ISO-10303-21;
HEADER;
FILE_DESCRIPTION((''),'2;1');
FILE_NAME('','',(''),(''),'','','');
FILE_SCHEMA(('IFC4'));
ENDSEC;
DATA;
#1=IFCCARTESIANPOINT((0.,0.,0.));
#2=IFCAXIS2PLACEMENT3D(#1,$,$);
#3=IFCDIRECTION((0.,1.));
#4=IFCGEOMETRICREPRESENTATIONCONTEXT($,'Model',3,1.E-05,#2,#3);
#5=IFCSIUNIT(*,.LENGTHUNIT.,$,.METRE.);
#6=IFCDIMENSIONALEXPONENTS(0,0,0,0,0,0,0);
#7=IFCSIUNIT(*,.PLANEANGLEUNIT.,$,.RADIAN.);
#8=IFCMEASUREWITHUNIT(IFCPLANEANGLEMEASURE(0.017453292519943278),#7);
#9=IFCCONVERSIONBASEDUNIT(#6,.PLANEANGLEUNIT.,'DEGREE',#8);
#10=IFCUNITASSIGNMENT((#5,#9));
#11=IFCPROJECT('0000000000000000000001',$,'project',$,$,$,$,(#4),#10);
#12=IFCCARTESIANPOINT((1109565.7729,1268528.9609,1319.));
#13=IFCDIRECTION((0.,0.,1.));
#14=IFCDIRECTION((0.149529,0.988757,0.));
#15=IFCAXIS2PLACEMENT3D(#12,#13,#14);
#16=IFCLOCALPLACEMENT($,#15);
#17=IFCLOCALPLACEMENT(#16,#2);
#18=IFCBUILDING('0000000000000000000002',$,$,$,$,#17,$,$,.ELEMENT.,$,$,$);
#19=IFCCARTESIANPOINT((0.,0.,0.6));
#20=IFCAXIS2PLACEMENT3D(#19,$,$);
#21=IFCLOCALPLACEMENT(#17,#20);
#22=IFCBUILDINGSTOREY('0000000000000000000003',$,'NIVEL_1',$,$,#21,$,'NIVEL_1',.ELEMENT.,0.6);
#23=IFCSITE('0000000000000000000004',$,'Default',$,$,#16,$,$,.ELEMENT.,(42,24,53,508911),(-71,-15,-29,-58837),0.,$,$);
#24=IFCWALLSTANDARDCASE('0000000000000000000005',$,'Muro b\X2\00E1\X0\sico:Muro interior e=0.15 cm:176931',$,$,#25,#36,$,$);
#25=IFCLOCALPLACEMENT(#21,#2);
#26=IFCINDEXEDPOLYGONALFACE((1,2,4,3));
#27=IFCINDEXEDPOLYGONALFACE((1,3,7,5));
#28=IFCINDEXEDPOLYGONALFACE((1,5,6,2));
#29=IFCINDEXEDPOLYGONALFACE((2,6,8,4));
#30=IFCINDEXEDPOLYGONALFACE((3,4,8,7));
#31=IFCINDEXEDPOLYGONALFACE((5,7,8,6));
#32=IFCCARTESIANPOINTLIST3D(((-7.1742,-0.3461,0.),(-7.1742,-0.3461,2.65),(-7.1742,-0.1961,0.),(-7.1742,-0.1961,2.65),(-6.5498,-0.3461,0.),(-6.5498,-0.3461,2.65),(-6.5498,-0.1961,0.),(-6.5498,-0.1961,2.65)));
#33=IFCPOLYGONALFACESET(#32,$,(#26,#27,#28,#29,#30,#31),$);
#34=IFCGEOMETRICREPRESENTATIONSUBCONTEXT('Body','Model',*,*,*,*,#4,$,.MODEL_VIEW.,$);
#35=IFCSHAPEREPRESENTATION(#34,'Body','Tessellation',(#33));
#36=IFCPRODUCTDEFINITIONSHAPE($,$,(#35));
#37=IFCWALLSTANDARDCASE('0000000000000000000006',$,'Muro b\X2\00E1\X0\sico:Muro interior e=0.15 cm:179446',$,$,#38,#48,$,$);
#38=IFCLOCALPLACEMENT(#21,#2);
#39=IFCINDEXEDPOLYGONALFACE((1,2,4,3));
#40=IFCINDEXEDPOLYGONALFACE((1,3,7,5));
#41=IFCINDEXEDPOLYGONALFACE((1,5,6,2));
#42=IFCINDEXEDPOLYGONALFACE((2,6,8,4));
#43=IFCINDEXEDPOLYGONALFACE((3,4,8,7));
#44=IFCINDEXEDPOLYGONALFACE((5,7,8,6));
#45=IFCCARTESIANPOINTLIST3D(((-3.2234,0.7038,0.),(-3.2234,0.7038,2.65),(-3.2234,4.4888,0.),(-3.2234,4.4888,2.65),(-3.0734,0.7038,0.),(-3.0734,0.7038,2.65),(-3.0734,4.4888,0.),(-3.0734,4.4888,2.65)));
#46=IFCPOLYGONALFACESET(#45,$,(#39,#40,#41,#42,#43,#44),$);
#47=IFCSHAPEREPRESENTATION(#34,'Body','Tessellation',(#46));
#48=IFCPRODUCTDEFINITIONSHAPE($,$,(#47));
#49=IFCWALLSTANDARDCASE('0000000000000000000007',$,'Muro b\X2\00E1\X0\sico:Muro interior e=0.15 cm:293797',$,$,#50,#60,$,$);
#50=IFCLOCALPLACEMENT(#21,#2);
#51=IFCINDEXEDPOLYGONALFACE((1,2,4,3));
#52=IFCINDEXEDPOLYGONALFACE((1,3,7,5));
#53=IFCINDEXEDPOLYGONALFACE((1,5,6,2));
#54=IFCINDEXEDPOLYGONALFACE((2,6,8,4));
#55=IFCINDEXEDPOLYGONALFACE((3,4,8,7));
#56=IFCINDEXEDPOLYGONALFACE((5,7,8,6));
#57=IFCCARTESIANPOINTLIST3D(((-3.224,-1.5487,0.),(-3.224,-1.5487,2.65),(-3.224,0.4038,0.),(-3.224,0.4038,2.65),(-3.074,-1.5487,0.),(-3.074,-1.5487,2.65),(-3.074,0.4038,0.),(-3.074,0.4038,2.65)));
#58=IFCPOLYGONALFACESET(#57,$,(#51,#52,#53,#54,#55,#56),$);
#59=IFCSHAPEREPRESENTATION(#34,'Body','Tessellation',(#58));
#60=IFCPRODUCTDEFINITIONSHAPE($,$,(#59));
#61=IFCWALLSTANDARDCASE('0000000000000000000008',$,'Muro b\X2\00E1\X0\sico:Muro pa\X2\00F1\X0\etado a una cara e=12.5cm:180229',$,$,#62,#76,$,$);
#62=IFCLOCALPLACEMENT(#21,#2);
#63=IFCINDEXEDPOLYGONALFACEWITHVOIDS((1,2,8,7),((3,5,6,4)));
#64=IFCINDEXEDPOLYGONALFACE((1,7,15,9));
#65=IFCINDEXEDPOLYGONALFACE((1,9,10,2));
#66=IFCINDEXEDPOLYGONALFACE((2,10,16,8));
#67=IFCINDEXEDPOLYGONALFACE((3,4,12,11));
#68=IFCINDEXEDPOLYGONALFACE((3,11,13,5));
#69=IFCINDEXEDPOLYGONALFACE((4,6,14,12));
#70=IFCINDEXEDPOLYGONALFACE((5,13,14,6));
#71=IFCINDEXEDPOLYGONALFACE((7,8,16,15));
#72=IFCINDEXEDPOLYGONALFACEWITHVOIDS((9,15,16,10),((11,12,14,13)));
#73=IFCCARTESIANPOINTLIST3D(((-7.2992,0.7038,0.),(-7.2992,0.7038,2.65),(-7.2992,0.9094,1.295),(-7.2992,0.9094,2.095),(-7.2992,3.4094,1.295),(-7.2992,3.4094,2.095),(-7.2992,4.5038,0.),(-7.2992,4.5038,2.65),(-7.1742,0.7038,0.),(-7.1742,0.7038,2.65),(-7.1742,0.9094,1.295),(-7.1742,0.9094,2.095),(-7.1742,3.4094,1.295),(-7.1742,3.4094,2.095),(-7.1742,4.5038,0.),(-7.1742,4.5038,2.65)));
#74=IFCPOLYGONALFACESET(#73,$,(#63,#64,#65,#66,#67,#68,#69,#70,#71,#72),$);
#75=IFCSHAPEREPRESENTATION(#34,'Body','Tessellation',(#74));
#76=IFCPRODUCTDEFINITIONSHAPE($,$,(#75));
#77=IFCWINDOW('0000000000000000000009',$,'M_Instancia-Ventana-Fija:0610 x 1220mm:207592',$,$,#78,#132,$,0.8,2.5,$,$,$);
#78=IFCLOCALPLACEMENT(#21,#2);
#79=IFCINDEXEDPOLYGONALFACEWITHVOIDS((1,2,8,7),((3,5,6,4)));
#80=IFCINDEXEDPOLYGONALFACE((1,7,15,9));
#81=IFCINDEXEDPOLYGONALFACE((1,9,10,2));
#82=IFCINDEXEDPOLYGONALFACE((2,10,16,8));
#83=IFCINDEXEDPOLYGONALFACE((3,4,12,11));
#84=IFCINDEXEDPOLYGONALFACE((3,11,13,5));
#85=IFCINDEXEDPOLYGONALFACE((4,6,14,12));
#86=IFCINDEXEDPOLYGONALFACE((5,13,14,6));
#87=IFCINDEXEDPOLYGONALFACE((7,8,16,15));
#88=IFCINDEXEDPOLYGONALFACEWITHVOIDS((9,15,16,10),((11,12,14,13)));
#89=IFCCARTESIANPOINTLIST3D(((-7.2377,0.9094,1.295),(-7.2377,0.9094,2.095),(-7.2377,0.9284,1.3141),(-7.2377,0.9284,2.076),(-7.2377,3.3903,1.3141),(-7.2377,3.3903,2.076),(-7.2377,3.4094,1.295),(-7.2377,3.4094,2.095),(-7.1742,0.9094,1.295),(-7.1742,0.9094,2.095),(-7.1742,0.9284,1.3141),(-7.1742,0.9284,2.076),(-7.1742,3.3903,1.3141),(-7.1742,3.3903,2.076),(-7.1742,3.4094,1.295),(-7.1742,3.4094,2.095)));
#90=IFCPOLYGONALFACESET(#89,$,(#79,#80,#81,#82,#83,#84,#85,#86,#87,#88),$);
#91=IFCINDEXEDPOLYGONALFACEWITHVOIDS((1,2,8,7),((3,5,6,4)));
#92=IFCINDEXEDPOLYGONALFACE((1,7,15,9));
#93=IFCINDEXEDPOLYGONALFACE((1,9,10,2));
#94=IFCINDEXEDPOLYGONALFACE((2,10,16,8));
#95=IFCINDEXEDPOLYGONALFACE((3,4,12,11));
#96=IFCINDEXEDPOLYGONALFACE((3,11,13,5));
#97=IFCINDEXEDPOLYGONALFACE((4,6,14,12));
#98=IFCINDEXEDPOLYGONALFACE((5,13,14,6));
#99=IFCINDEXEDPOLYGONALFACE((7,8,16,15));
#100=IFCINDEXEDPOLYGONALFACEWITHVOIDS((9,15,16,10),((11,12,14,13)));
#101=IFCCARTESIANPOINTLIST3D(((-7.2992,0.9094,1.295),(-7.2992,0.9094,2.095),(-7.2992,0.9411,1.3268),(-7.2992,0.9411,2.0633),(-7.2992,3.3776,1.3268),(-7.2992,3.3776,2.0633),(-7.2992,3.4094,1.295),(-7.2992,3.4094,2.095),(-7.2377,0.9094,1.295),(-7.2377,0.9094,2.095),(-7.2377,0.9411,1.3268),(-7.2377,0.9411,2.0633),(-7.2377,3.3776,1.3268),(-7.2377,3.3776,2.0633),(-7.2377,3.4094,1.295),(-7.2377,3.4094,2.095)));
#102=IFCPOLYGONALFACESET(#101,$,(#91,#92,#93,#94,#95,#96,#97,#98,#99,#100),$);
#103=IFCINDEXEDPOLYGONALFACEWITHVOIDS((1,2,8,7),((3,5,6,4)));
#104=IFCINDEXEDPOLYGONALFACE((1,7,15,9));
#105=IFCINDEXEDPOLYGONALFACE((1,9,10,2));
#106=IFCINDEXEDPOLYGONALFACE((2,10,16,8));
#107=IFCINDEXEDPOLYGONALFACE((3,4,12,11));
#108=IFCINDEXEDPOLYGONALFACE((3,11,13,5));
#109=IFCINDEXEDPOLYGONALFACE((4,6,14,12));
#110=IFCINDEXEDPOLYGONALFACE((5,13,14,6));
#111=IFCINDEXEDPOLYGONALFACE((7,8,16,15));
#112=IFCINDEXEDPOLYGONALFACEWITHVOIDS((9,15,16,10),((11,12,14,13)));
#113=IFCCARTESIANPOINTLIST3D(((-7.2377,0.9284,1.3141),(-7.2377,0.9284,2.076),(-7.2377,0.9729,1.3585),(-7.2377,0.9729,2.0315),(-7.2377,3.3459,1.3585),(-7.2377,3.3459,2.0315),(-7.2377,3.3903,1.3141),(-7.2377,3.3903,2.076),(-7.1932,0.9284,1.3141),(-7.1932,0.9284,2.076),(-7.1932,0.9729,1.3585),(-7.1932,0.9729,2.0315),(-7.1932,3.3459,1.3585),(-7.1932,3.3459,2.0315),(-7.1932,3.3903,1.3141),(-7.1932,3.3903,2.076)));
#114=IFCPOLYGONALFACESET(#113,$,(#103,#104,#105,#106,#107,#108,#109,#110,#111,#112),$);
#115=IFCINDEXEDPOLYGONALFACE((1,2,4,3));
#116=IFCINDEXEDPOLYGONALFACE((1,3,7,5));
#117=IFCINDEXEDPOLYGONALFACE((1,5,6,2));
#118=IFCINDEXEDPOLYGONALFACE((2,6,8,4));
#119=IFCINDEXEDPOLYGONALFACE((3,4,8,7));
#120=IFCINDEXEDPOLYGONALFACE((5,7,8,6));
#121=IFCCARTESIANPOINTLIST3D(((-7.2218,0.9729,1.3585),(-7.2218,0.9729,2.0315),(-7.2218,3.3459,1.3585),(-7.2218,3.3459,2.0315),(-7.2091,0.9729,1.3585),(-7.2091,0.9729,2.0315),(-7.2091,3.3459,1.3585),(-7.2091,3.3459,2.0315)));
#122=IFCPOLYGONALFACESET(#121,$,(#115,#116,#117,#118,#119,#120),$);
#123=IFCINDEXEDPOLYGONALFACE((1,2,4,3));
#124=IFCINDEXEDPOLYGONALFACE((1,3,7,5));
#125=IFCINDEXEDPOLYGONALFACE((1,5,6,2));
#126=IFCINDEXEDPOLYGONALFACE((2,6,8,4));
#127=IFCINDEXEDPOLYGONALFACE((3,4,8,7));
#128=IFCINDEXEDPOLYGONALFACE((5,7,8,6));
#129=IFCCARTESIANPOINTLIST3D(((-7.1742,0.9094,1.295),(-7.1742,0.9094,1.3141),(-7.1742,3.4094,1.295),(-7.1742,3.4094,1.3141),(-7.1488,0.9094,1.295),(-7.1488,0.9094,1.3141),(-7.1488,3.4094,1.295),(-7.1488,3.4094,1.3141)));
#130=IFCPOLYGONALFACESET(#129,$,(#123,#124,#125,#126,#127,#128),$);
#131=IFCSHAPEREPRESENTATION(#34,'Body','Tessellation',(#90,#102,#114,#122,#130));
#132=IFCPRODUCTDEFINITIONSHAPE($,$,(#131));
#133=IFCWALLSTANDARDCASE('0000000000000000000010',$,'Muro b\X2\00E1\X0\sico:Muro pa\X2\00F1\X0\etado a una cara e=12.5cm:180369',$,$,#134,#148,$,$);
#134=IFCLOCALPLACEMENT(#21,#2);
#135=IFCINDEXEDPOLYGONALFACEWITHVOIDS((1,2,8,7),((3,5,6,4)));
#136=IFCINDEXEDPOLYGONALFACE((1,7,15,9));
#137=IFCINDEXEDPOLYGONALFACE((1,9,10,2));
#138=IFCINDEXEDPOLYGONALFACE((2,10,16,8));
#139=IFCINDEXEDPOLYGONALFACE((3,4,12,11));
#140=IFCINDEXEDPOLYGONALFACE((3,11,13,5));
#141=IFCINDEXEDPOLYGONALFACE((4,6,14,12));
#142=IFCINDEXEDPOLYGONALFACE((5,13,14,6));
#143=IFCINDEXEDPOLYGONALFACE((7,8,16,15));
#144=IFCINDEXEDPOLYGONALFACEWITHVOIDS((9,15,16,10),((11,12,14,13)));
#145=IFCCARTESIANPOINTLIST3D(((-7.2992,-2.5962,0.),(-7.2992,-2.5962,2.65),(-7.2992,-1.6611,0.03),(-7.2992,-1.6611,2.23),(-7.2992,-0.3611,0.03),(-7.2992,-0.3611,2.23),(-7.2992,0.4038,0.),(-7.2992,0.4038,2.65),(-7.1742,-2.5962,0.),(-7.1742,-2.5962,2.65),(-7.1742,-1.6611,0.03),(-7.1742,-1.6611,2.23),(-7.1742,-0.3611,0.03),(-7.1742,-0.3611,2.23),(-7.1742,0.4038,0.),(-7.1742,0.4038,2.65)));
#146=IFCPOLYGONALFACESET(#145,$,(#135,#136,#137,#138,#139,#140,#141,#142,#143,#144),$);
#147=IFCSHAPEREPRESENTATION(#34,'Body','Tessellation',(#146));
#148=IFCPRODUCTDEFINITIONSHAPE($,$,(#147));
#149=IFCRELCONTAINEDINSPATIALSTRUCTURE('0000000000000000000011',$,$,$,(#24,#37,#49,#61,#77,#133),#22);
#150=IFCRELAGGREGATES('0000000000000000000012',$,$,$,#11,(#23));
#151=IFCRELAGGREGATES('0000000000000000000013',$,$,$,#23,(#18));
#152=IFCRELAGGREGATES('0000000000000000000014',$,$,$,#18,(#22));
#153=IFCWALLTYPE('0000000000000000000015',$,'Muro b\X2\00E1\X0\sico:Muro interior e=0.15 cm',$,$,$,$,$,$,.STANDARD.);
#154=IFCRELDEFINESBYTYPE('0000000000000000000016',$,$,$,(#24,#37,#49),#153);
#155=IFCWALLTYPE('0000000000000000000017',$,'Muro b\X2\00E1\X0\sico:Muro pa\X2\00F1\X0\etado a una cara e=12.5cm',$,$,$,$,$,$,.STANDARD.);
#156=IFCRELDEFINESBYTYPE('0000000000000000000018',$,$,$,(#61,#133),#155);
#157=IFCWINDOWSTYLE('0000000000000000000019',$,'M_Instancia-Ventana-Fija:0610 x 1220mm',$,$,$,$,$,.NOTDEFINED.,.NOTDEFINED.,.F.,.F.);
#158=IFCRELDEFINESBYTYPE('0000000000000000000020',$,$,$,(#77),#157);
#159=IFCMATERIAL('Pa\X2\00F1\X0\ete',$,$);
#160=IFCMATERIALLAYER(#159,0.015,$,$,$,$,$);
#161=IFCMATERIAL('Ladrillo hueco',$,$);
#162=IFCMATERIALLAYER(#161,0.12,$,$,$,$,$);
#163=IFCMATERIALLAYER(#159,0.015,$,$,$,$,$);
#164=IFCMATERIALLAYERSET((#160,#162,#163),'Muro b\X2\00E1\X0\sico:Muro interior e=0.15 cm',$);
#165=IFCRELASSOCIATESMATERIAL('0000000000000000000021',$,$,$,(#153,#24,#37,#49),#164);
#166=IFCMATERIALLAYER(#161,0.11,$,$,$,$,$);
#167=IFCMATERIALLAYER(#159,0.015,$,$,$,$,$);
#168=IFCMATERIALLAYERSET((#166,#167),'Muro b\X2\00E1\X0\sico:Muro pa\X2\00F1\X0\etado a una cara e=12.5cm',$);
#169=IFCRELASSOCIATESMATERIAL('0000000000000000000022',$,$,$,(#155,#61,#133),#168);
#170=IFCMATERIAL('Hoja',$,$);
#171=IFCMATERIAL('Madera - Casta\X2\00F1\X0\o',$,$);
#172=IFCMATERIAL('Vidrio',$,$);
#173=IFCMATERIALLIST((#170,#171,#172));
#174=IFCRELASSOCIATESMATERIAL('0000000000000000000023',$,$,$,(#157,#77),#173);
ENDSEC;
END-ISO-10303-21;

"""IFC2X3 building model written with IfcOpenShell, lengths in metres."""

from ifc_helpers import new_model, entity, si_unit, converted_unit, direction, frame, frame_2d, origin, origin_2d_with_axis, place, context, subcontext, project, spatial, polyline, rectangle, outline, extrude, source, transform, mapped, material, material_list, layer, layer_set, layer_usage, type_object, type_shapes, element, fill, save


model = new_model("IFC2X3")

# Units and contexts
model_context = context("Model", 3, precision=1e-05, world=origin(), true_north=direction((0.0, 1.0)))
body_context = subcontext(model_context, "Body", "Model", "MODEL_VIEW")
ifc_project = project(units=[si_unit("LENGTHUNIT", "METRE"), converted_unit("PLANEANGLEUNIT", "DEGREE", entity("IfcPlaneAngleMeasure", 0.017453292519943278), si_unit("PLANEANGLEUNIT", "RADIAN"), dimensions=[0, 0, 0, 0, 0, 0, 0])], contexts=[model_context])

# Site, building, storey
site_placement = place(None, frame((1109565.7729, 1268528.9609, 1319.0), z_axis=(0.0, 0.0, 1.0), x_axis=(0.149529, 0.988757, 0.0)))
site = spatial("IfcSite", under=ifc_project, at=site_placement, Name="Default", CompositionType="ELEMENT", RefLatitude=(42, 24, 53, 508911), RefLongitude=(-71, -15, -29, -58837), RefElevation=0.0)
building_placement = place(site_placement, origin())
building = spatial("IfcBuilding", under=site, at=building_placement, CompositionType="ELEMENT")
storey_placement = place(building_placement, frame((0.0, 0.0, 0.6)))
storey = spatial("IfcBuildingStorey", under=building, at=storey_placement, Name="NIVEL_1", LongName="NIVEL_1", CompositionType="ELEMENT", Elevation=0.6)

# Walls
ifc_material_1 = material(Name="Pañete")
ifc_layer_1 = layer(ifc_material_1, 0.015)
ifc_material_2 = material(Name="Ladrillo hueco")
ifc_layer_2 = layer(ifc_material_2, 0.12)
ifc_layer_3 = layer(ifc_material_1, 0.015)
ifc_layer_set_1 = layer_set([ifc_layer_1, ifc_layer_2, ifc_layer_3], Name="Muro básico:Muro interior e=0.15 cm")
ifc_layer_usage_1 = layer_usage(ifc_layer_set_1, "AXIS2", "NEGATIVE", 0.075)
wall_type_1 = type_object("IfcWallType", Name="Muro básico:Muro interior e=0.15 cm", PredefinedType="STANDARD", material=ifc_layer_set_1)
wall_1_placement = place(storey_placement, frame((-6.5498, -0.2711, 0.0), z_axis=(0.0, 0.0, 1.0), x_axis=(-1.0, 0.0, 0.0)))
element("IfcWallStandardCase", 1, at=wall_1_placement, inside=storey, type_object=wall_type_1, material=ifc_layer_usage_1, Name="Muro básico:Muro interior e=0.15 cm:176931", context=body_context, shape_type="SweptSolid", body=[
    extrude(rectangle(XDim=0.6244, YDim=0.15, at=frame_2d((0.3122, 0.0), x_axis=(-1.0, 0.0))), origin(), (0.0, 0.0, 1.0), 2.65),
])
ifc_layer_usage_2 = layer_usage(ifc_layer_set_1, "AXIS2", "NEGATIVE", 0.075)
wall_2_placement = place(storey_placement, frame((-3.1484, 0.7038, 0.0), z_axis=(0.0, 0.0, 1.0), x_axis=(0.0, 1.0, 0.0)))
element("IfcWallStandardCase", 2, at=wall_2_placement, inside=storey, type_object=wall_type_1, material=ifc_layer_usage_2, Name="Muro básico:Muro interior e=0.15 cm:179446", context=body_context, shape_type="SweptSolid", body=[
    extrude(rectangle(XDim=3.785, YDim=0.15, at=frame_2d((1.8925, 0.0), x_axis=(-1.0, 0.0))), origin(), (0.0, 0.0, 1.0), 2.65),
])
ifc_layer_usage_3 = layer_usage(ifc_layer_set_1, "AXIS2", "POSITIVE", -0.075)
wall_3_placement = place(storey_placement, frame((-3.149, -1.5487, 0.0), z_axis=(0.0, 0.0, 1.0), x_axis=(0.0, 1.0, 0.0)))
element("IfcWallStandardCase", 3, at=wall_3_placement, inside=storey, type_object=wall_type_1, material=ifc_layer_usage_3, Name="Muro básico:Muro interior e=0.15 cm:293797", context=body_context, shape_type="SweptSolid", body=[
    extrude(rectangle(XDim=1.9525, YDim=0.15, at=frame_2d((0.9763, 0.0), x_axis=(-1.0, 0.0))), origin(), (0.0, 0.0, 1.0), 2.65),
])

# Wall, opening, window
ifc_layer_4 = layer(ifc_material_2, 0.11)
ifc_layer_5 = layer(ifc_material_1, 0.015)
ifc_layer_set_2 = layer_set([ifc_layer_4, ifc_layer_5], Name="Muro básico:Muro pañetado a una cara e=12.5cm")
ifc_layer_usage_4 = layer_usage(ifc_layer_set_2, "AXIS2", "NEGATIVE", 0.0625)
wall_type_2 = type_object("IfcWallType", Name="Muro básico:Muro pañetado a una cara e=12.5cm", PredefinedType="STANDARD", material=ifc_layer_set_2)
wall_4_placement = place(storey_placement, frame((-7.2367, 0.7038, 0.0), z_axis=(0.0, 0.0, 1.0), x_axis=(0.0, 1.0, 0.0)))
wall_4 = element("IfcWallStandardCase", 4, at=wall_4_placement, inside=storey, type_object=wall_type_2, material=ifc_layer_usage_4, Name="Muro básico:Muro pañetado a una cara e=12.5cm:180229", context=body_context, shape_type="SweptSolid", body=[
    extrude(rectangle(XDim=3.8, YDim=0.125, at=frame_2d((1.9, 0.0), x_axis=(-1.0, 0.0))), origin(), (0.0, 0.0, 1.0), 2.65),
])
opening_1_placement = place(wall_4_placement, frame((2.7056, 0.0625, 1.295)))
opening_1 = element("IfcOpeningElement", 5, at=opening_1_placement, cuts=wall_4, ObjectType="Opening", context=body_context, shape_type="SweptSolid", body=[
    extrude(rectangle(XDim=0.8, YDim=2.5, at=frame_2d((0.4, 1.25), x_axis=(-1.0, 0.0))), frame((0.0, 0.0, 0.0), z_axis=(0.0, -1.0, 0.0), x_axis=(0.0, 0.0, 1.0)), (0.0, 0.0, 1.0), 0.125),
])
ifc_material_3 = material(Name="Hoja")
ifc_material_4 = material(Name="Madera - Castaño")
ifc_material_5 = material(Name="Vidrio")
ifc_material_list_1 = material_list([ifc_material_3, ifc_material_4, ifc_material_5])
window_style = type_object("IfcWindowStyle", Name="M_Instancia-Ventana-Fija:0610 x 1220mm", ConstructionType="NOTDEFINED", OperationType="NOTDEFINED", ParameterTakesPrecedence=False, Sizeable=False, material=ifc_material_list_1)
shared_shape_1 = source(origin(), body_context, "Body", "SweptSolid", [
    extrude(outline(polyline([(-0.4, -1.25), (0.4, -1.25), (0.4, 1.25), (-0.4, 1.25), (-0.4, -1.25)]), holes=[polyline([(-0.3809, -1.2309), (-0.3809, 1.2309), (0.381, 1.2309), (0.381, -1.2309), (-0.3809, -1.2309)])]), frame((1.25, 0.0616, 0.4), z_axis=(0.0, 1.0, 0.0), x_axis=(0.0, 0.0, -1.0)), (0.0, 0.0, 1.0), 0.0635),
    extrude(outline(polyline([(-1.25, -0.4), (1.25, -0.4), (1.25, 0.4), (-1.25, 0.4), (-1.25, -0.4)]), holes=[polyline([(-1.2182, -0.3682), (-1.2182, 0.3683), (1.2182, 0.3683), (1.2182, -0.3682), (-1.2182, -0.3682)])]), frame((1.25, 0.0, 0.4), z_axis=(0.0, 1.0, 0.0), x_axis=(1.0, 0.0, 0.0)), (0.0, 0.0, 1.0), 0.0616),
    extrude(outline(polyline([(-1.2309, -0.381), (1.2309, -0.381), (1.2309, 0.381), (-1.2309, 0.381), (-1.2309, -0.381)]), holes=[polyline([(-1.1865, -0.3365), (-1.1865, 0.3365), (1.1865, 0.3365), (1.1865, -0.3365), (-1.1865, -0.3365)])]), frame((1.25, 0.0616, 0.4), z_axis=(0.0, 1.0, 0.0), x_axis=(1.0, 0.0, 0.0)), (0.0, 0.0, 1.0), 0.0444),
    extrude(rectangle(XDim=0.0127, YDim=2.373, at=origin_2d_with_axis()), frame((1.25, 0.0838, 0.0635), z_axis=(0.0, 0.0, 1.0), x_axis=(0.0, 1.0, 0.0)), (0.0, 0.0, 1.0), 0.673),
    extrude(rectangle(XDim=0.0254, YDim=2.5, at=origin_2d_with_axis()), frame((1.25, 0.1377, 0.0), z_axis=(0.0, 0.0, 1.0), x_axis=(0.0, -1.0, 0.0)), (0.0, 0.0, 1.0), 0.019),
])
type_shapes(window_style, [shared_shape_1])
window_placement = place(opening_1_placement, frame((0.0, 0.0, 0.0), z_axis=(0.0, 0.0, 1.0), x_axis=(-1.0, 0.0, 0.0)))
window = element("IfcWindow", 6, at=window_placement, inside=storey, type_object=window_style, material=ifc_material_list_1, Name="M_Instancia-Ventana-Fija:0610 x 1220mm:207592", OverallHeight=0.8, OverallWidth=2.5, context=body_context, shape_type="MappedRepresentation", body=[
    mapped(shared_shape_1, transform((0.0, 0.0, 0.0), scale=1.0)),
])
fill(opening_1, window)

# Wall, opening
ifc_layer_usage_5 = layer_usage(ifc_layer_set_2, "AXIS2", "POSITIVE", -0.0625)
wall_5_placement = place(storey_placement, frame((-7.2367, 0.4038, 0.0), z_axis=(0.0, 0.0, 1.0), x_axis=(0.0, -1.0, 0.0)))
wall_5 = element("IfcWallStandardCase", 7, at=wall_5_placement, inside=storey, type_object=wall_type_2, material=ifc_layer_usage_5, Name="Muro básico:Muro pañetado a una cara e=12.5cm:180369", context=body_context, shape_type="SweptSolid", body=[
    extrude(rectangle(XDim=3.0, YDim=0.125, at=frame_2d((1.5, 0.0), x_axis=(-1.0, 0.0))), origin(), (0.0, 0.0, 1.0), 2.65),
])
opening_2_placement = place(wall_5_placement, frame((0.7649, -0.0625, 0.03)))
element("IfcOpeningElement", 8, at=opening_2_placement, cuts=wall_5, ObjectType="Opening", context=body_context, shape_type="SweptSolid", body=[
    extrude(rectangle(XDim=2.2, YDim=1.3, at=frame_2d((1.1, 0.65), x_axis=(1.0, 0.0))), frame((0.0, 0.0, 0.0), z_axis=(0.0, 1.0, 0.0), x_axis=(0.0, 0.0, 1.0)), (0.0, 0.0, 1.0), 0.125),
])

save(model, "model.ifc")
